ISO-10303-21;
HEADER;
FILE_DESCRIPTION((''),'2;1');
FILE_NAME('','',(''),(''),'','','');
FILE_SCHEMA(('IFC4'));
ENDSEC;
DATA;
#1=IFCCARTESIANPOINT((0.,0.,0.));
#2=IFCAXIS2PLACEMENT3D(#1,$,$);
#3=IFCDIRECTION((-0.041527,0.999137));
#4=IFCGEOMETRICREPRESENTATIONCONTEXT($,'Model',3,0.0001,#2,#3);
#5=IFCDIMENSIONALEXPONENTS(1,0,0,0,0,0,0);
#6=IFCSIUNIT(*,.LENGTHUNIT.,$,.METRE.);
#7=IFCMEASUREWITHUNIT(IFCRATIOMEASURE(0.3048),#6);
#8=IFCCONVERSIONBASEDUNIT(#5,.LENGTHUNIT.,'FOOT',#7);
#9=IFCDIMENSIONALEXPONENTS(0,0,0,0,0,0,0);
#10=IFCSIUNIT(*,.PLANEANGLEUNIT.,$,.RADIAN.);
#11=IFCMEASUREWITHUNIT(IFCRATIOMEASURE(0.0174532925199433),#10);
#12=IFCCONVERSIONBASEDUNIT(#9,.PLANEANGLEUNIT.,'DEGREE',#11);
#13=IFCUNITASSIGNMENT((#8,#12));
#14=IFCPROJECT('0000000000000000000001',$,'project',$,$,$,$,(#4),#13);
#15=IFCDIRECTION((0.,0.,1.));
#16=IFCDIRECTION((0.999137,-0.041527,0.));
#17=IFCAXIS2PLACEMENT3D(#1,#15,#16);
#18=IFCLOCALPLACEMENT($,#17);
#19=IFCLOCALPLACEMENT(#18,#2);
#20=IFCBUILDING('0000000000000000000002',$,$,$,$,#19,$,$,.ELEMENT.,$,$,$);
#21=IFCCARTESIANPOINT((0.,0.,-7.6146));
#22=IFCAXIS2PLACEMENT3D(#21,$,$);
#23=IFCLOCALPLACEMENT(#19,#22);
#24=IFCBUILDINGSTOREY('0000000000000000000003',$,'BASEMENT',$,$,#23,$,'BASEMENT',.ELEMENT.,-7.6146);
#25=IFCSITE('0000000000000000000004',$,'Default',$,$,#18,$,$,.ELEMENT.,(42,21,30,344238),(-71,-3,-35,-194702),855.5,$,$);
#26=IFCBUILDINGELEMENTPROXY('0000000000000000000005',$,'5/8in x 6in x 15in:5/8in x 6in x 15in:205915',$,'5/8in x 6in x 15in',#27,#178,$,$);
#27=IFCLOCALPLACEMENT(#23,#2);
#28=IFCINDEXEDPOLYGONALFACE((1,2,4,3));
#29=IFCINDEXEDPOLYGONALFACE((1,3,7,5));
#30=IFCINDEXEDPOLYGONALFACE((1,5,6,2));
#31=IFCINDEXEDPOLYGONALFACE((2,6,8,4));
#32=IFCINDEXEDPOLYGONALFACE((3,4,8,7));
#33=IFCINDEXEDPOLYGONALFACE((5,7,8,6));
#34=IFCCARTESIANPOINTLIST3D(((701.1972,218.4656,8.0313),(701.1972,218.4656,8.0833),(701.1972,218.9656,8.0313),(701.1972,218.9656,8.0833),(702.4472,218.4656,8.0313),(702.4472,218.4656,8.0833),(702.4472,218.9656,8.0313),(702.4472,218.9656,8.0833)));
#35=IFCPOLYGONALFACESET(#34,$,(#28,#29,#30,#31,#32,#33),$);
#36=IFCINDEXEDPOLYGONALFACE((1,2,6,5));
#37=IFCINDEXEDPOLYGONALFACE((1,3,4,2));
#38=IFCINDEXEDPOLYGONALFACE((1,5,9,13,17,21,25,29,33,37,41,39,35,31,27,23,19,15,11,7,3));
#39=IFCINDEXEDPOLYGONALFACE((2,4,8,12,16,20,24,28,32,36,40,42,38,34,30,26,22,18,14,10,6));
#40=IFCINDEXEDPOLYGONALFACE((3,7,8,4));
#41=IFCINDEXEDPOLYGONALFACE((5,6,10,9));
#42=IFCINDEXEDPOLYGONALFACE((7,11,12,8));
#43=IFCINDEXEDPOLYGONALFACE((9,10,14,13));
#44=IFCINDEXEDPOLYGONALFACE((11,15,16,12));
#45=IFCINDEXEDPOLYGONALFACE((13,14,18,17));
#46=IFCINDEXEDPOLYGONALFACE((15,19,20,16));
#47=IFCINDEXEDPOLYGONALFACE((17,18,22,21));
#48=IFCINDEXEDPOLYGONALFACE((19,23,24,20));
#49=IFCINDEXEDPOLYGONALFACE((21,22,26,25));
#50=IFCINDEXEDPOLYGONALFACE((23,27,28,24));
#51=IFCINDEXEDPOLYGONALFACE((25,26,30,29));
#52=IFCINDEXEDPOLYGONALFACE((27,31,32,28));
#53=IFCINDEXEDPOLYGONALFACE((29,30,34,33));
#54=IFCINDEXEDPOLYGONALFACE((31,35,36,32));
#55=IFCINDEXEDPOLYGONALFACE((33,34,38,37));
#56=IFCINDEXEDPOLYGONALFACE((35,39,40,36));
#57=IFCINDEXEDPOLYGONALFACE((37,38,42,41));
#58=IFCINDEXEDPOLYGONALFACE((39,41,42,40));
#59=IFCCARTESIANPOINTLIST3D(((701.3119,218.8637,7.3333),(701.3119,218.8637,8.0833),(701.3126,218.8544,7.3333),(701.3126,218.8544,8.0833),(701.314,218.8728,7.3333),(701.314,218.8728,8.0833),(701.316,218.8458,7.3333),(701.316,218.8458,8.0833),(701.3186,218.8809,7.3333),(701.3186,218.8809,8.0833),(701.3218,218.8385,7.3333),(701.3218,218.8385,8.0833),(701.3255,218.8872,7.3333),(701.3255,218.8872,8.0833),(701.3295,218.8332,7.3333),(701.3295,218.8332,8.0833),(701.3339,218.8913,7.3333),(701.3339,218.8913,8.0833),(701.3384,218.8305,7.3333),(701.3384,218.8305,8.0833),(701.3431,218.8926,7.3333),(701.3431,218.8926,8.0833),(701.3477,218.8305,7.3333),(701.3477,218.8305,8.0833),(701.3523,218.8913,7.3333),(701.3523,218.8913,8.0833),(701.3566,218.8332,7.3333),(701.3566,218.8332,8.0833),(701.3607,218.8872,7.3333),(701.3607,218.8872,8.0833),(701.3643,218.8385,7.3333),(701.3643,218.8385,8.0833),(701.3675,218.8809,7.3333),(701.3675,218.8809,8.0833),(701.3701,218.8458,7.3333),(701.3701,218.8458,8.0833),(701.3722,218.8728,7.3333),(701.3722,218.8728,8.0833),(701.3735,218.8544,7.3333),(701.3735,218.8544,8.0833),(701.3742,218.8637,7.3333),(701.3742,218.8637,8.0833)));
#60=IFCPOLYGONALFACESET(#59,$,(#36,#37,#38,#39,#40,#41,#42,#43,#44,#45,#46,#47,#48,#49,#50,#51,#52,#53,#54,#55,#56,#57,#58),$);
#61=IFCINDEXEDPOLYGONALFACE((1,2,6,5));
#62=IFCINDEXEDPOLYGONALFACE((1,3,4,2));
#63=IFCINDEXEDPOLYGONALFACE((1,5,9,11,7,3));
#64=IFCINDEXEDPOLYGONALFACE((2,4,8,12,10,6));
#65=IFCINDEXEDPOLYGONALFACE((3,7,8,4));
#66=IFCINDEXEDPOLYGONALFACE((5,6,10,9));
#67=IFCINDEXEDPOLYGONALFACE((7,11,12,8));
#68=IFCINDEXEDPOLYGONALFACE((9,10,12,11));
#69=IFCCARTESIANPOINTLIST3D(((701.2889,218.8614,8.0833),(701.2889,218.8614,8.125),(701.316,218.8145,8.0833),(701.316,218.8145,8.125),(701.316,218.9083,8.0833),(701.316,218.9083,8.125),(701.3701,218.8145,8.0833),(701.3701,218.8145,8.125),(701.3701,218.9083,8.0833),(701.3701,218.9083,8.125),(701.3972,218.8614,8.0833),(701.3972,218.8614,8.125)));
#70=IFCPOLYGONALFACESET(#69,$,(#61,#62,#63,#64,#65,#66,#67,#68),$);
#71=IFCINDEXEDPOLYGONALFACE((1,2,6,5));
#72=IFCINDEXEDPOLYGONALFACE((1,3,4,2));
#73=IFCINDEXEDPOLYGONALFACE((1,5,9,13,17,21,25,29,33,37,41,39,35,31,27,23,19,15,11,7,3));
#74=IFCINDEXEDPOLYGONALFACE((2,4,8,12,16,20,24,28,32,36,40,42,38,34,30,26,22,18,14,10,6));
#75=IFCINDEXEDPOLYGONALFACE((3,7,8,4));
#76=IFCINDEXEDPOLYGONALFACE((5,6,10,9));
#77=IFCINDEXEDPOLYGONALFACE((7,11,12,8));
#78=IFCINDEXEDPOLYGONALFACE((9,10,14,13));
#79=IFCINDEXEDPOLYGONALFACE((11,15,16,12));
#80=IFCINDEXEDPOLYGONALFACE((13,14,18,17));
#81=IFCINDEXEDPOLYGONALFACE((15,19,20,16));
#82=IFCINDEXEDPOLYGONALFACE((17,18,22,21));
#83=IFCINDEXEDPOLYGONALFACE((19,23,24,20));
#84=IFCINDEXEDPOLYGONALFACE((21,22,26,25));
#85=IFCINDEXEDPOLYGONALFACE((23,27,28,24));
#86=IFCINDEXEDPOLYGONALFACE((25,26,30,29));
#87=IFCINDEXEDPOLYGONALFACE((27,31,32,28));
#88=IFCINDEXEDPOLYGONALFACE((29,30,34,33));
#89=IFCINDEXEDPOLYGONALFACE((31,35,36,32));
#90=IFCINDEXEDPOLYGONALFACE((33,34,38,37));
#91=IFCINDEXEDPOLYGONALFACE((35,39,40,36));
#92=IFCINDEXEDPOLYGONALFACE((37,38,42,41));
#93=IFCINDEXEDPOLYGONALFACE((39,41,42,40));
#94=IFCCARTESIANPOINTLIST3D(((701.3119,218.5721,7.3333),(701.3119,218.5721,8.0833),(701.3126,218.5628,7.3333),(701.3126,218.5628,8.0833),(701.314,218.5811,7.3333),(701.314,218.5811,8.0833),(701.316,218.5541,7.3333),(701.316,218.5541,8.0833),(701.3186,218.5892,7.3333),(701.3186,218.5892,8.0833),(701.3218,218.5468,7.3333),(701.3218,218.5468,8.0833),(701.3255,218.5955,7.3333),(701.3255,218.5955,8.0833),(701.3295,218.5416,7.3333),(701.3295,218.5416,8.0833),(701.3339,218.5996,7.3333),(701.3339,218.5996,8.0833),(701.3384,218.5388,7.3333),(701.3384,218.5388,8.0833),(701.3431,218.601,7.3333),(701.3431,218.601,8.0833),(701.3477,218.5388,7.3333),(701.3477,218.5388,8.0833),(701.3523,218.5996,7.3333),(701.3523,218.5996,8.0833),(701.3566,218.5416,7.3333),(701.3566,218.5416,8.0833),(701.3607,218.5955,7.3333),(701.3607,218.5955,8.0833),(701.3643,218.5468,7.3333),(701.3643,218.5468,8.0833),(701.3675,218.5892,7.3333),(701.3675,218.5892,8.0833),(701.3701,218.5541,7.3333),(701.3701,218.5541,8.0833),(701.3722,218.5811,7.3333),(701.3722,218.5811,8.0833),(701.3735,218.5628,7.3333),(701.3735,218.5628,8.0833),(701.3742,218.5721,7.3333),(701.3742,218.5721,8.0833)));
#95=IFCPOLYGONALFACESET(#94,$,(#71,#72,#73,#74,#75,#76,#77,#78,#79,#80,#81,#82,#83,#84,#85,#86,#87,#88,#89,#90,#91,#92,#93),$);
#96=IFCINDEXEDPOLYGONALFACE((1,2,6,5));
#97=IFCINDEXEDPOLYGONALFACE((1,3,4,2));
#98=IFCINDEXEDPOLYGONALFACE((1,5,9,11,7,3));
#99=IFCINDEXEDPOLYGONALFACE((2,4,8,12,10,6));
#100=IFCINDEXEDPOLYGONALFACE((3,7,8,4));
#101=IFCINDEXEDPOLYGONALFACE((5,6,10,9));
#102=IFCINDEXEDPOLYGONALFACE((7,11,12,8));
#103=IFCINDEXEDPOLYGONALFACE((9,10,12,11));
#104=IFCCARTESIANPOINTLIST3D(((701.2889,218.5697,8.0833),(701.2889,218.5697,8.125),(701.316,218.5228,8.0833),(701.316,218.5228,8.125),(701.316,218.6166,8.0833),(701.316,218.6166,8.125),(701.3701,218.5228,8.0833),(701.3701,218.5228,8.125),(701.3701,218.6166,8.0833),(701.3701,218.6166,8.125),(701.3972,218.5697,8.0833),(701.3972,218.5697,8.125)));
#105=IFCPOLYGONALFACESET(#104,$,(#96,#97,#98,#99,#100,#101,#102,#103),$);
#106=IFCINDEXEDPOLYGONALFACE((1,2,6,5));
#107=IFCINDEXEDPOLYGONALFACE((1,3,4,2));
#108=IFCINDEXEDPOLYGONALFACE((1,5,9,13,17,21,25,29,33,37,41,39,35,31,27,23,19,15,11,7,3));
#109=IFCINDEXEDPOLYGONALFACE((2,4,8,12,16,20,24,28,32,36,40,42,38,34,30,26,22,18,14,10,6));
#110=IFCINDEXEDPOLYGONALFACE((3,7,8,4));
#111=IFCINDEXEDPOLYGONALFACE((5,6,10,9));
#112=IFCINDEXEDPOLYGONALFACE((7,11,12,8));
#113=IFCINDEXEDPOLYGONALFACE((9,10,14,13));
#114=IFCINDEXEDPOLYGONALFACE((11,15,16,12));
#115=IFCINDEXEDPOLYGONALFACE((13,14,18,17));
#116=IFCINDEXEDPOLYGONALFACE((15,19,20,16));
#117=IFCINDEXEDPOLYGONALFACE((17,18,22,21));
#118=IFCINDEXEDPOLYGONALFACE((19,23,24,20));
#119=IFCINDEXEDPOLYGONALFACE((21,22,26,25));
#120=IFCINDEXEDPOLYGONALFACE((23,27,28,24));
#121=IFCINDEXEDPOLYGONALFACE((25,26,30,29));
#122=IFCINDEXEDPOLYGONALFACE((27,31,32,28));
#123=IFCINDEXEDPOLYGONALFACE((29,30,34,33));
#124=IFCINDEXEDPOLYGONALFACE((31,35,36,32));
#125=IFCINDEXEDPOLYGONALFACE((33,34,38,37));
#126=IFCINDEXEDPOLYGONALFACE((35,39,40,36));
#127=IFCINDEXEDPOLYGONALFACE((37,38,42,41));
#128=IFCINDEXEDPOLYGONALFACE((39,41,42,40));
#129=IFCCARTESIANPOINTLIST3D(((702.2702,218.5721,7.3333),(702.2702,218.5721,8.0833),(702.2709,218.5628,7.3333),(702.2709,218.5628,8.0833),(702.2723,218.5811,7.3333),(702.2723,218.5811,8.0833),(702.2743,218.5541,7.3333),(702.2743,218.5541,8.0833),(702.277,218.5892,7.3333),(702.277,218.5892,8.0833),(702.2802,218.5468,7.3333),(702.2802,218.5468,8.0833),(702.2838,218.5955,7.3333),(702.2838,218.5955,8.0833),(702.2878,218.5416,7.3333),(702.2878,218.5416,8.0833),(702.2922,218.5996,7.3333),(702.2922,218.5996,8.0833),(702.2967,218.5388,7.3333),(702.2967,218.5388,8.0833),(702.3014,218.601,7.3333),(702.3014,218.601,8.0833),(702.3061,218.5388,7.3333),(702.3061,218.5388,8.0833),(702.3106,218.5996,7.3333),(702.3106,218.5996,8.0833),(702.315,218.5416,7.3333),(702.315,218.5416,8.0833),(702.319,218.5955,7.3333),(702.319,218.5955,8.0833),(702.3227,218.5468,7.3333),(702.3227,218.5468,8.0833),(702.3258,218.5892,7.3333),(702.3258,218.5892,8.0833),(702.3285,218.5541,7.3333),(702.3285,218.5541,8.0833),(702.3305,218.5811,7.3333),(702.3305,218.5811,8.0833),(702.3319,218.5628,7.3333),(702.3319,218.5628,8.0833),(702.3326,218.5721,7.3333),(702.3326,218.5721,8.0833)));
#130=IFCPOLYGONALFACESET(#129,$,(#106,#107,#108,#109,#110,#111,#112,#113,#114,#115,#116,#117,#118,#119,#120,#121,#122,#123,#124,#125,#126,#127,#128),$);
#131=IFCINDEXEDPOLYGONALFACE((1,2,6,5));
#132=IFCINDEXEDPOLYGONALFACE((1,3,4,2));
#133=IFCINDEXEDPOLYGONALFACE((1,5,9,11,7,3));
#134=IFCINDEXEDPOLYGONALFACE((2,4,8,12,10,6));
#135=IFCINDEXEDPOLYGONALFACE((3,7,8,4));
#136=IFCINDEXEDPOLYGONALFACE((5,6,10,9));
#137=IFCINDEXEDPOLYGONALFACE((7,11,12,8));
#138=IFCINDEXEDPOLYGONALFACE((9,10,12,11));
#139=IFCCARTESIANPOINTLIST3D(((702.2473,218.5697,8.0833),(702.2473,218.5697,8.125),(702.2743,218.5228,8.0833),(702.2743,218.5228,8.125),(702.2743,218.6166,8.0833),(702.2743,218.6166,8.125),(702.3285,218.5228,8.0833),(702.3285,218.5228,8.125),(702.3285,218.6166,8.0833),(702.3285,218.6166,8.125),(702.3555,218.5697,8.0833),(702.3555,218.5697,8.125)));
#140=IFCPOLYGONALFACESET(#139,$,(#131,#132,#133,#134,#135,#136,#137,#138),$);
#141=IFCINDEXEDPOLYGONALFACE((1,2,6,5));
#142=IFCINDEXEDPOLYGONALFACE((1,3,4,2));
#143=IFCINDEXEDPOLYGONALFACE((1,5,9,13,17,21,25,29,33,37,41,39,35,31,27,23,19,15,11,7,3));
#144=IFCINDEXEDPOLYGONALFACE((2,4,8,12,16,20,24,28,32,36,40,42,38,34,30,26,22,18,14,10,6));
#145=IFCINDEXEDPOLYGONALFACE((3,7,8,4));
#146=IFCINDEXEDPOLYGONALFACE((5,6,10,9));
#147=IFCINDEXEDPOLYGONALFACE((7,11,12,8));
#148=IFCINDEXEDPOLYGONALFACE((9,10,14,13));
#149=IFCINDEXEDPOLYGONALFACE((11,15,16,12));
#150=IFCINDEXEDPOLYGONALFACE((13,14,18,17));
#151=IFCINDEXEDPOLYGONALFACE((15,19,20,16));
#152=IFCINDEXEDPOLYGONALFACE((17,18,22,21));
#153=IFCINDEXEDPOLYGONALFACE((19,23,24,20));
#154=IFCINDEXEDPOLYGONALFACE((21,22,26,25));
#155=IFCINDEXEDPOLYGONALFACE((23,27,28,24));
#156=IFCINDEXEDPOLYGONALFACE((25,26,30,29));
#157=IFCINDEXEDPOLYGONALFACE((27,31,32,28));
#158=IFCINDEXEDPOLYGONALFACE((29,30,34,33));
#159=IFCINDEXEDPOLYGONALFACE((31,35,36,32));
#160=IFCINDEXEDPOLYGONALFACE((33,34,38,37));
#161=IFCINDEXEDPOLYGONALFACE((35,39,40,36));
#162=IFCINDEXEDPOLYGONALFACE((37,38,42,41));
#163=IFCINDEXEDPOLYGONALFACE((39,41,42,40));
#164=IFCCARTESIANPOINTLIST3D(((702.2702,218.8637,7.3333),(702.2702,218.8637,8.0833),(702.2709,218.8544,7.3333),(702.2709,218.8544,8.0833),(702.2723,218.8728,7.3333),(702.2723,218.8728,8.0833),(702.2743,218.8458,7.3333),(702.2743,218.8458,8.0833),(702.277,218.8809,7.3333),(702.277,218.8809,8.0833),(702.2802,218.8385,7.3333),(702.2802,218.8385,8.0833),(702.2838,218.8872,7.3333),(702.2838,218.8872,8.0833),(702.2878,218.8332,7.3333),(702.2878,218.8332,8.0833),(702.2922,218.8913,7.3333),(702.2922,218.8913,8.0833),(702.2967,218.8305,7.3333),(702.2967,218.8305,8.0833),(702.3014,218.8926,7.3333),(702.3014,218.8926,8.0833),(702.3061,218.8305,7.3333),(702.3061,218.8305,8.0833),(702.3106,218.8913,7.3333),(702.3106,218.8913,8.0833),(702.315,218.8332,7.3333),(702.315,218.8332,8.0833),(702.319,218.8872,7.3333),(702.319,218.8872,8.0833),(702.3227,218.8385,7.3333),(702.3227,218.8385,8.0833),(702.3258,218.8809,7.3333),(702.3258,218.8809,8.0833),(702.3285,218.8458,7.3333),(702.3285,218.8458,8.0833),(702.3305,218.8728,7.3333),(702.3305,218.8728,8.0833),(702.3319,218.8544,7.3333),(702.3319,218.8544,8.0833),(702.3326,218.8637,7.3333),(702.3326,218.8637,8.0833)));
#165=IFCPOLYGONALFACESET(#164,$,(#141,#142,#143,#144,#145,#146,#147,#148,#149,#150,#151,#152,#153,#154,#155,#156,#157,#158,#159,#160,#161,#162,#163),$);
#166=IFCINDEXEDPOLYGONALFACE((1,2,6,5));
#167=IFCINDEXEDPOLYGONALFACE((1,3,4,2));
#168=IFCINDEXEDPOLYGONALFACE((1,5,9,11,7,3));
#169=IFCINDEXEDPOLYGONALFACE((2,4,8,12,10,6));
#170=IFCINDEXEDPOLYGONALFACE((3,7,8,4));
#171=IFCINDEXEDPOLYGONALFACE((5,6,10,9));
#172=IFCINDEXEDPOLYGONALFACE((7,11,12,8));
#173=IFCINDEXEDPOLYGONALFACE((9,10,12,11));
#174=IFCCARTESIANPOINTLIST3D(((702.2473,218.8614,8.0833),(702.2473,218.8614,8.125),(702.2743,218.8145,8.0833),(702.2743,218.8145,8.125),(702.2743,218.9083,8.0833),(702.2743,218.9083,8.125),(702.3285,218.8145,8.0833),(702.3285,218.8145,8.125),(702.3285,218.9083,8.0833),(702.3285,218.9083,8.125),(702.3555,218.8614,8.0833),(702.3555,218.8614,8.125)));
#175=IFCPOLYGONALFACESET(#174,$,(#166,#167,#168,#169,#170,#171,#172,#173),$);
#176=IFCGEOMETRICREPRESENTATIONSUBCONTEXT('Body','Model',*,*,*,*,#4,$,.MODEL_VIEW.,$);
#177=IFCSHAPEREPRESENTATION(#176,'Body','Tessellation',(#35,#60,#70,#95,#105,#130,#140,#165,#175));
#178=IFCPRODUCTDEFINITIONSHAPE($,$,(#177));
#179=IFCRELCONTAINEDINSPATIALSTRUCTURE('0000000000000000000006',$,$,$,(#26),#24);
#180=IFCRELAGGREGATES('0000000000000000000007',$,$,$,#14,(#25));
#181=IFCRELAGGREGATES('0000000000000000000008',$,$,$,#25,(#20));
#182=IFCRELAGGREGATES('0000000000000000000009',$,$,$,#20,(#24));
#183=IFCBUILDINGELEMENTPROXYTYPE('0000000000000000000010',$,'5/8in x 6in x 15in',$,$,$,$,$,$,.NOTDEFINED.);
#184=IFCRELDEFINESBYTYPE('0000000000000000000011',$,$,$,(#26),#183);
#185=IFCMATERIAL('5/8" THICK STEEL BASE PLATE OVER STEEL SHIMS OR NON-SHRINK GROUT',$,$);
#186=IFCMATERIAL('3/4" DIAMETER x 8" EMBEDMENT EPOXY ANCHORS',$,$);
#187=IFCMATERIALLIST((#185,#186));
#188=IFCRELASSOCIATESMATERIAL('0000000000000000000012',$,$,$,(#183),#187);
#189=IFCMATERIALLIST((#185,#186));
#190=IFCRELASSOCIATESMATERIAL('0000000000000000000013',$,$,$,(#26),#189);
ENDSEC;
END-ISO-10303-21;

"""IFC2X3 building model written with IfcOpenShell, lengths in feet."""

from ifc_helpers import new_model, entity, si_unit, converted_unit, direction, frame, frame_2d, origin, origin_2d_with_axis, place, context, subcontext, project, spatial, polyline, rectangle, circle, outline, extrude, source, transform, mapped, material, material_list, type_object, type_shapes, element, save


model = new_model("IFC2X3")

# Units and contexts
model_context = context("Model", 3, precision=0.0001, world=origin(), true_north=direction((-0.041527, 0.999137)))
body_context = subcontext(model_context, "Body", "Model", "MODEL_VIEW")
ifc_project = project(units=[converted_unit("LENGTHUNIT", "FOOT", entity("IfcRatioMeasure", 0.3048), si_unit("LENGTHUNIT", "METRE"), dimensions=[1, 0, 0, 0, 0, 0, 0]), converted_unit("PLANEANGLEUNIT", "DEGREE", entity("IfcRatioMeasure", 0.0174532925199433), si_unit("PLANEANGLEUNIT", "RADIAN"), dimensions=[0, 0, 0, 0, 0, 0, 0])], contexts=[model_context])

# Site, building, storey
site_placement = place(None, frame((0.0, 0.0, 0.0), z_axis=(0.0, 0.0, 1.0), x_axis=(0.999137, -0.041527, 0.0)))
site = spatial("IfcSite", under=ifc_project, at=site_placement, Name="Default", CompositionType="ELEMENT", RefLatitude=(42, 21, 30, 344238), RefLongitude=(-71, -3, -35, -194702), RefElevation=855.5)
building_placement = place(site_placement, origin())
building = spatial("IfcBuilding", under=site, at=building_placement, CompositionType="ELEMENT")
storey_placement = place(building_placement, frame((0.0, 0.0, -7.6146)))
storey = spatial("IfcBuildingStorey", under=building, at=storey_placement, Name="BASEMENT", LongName="BASEMENT", CompositionType="ELEMENT", Elevation=-7.6146)

# Building element proxy
ifc_material_1 = material(Name="5/8\" THICK STEEL BASE PLATE OVER STEEL SHIMS OR NON-SHRINK GROUT")
ifc_material_2 = material(Name="3/4\" DIAMETER x 8\" EMBEDMENT EPOXY ANCHORS")
ifc_material_list_1 = material_list([ifc_material_1, ifc_material_2])
building_element_proxy_type_1 = type_object("IfcBuildingElementProxyType", Name="5/8in x 6in x 15in", PredefinedType="NOTDEFINED", material=ifc_material_list_1)
shared_shape_1 = source(origin(), body_context, "Body", "SweptSolid", [
    extrude(rectangle(XDim=1.25, YDim=0.5, at=origin_2d_with_axis()), frame((0.0417, 0.0668, 0.0), z_axis=(0.0, 0.0, 1.0), x_axis=(0.0, -1.0, 0.0)), (0.0, 0.0, 1.0), 0.0521),
    extrude(circle(Radius=0.0312, at=origin_2d_with_axis()), frame((0.1875, 0.546, -0.6979)), (0.0, 0.0, 1.0), 0.75),
    extrude(outline(polyline([(-0.0271, -0.0469), (0.0271, -0.0469), (0.0541, 0.0), (0.0271, 0.0469), (-0.0271, 0.0469), (-0.0541, 0.0), (-0.0271, -0.0469)])), frame((0.1875, 0.546, 0.0521), z_axis=(0.0, 0.0, 1.0), x_axis=(0.866025, -0.5, 0.0)), (0.0, 0.0, 1.0), 0.0417),
    extrude(circle(Radius=0.0312, at=frame_2d((0.0, 0.0), x_axis=(1.0, 0.0))), frame((-0.1042, 0.546, -0.6979)), (0.0, 0.0, 1.0), 0.75),
    extrude(outline(polyline([(-0.0271, -0.0469), (0.0271, -0.0469), (0.0541, 0.0), (0.0271, 0.0469), (-0.0271, 0.0469), (-0.0541, 0.0), (-0.0271, -0.0469)])), frame((-0.1042, 0.546, 0.0521), z_axis=(0.0, 0.0, 1.0), x_axis=(0.866025, -0.5, 0.0)), (0.0, 0.0, 1.0), 0.0417),
    extrude(circle(Radius=0.0312, at=frame_2d((0.0, 0.0), x_axis=(1.0, 0.0))), frame((-0.1042, -0.4124, -0.6979)), (0.0, 0.0, 1.0), 0.75),
    extrude(outline(polyline([(-0.0271, -0.0469), (0.0271, -0.0469), (0.0541, 0.0), (0.0271, 0.0469), (-0.0271, 0.0469), (-0.0541, 0.0), (-0.0271, -0.0469)])), frame((-0.1042, -0.4124, 0.0521), z_axis=(0.0, 0.0, 1.0), x_axis=(0.866025, -0.5, 0.0)), (0.0, 0.0, 1.0), 0.0417),
    extrude(circle(Radius=0.0312, at=frame_2d((0.0, 0.0), x_axis=(1.0, 0.0))), frame((0.1875, -0.4124, -0.6979)), (0.0, 0.0, 1.0), 0.75),
    extrude(outline(polyline([(-0.0271, -0.0469), (0.0271, -0.0469), (0.0541, 0.0), (0.0271, 0.0469), (-0.0271, 0.0469), (-0.0541, 0.0), (-0.0271, -0.0469)])), frame((0.1875, -0.4124, 0.0521), z_axis=(0.0, 0.0, 1.0), x_axis=(0.866025, -0.5, 0.0)), (0.0, 0.0, 1.0), 0.0417),
])
type_shapes(building_element_proxy_type_1, [shared_shape_1])
ifc_material_list_2 = material_list([ifc_material_1, ifc_material_2])
proxy_1_placement = place(storey_placement, frame((701.8891, 218.6739, 8.0313), z_axis=(0.0, 0.0, 1.0), x_axis=(0.0, 1.0, 0.0)))
element("IfcBuildingElementProxy", 1, at=proxy_1_placement, inside=storey, type_object=building_element_proxy_type_1, material=ifc_material_list_2, Name="5/8in x 6in x 15in:5/8in x 6in x 15in:205915", ObjectType="5/8in x 6in x 15in", context=body_context, shape_type="MappedRepresentation", body=[
    mapped(shared_shape_1, transform((0.0, 0.0, 0.0), scale=1.0)),
])

save(model, "model.ifc")
